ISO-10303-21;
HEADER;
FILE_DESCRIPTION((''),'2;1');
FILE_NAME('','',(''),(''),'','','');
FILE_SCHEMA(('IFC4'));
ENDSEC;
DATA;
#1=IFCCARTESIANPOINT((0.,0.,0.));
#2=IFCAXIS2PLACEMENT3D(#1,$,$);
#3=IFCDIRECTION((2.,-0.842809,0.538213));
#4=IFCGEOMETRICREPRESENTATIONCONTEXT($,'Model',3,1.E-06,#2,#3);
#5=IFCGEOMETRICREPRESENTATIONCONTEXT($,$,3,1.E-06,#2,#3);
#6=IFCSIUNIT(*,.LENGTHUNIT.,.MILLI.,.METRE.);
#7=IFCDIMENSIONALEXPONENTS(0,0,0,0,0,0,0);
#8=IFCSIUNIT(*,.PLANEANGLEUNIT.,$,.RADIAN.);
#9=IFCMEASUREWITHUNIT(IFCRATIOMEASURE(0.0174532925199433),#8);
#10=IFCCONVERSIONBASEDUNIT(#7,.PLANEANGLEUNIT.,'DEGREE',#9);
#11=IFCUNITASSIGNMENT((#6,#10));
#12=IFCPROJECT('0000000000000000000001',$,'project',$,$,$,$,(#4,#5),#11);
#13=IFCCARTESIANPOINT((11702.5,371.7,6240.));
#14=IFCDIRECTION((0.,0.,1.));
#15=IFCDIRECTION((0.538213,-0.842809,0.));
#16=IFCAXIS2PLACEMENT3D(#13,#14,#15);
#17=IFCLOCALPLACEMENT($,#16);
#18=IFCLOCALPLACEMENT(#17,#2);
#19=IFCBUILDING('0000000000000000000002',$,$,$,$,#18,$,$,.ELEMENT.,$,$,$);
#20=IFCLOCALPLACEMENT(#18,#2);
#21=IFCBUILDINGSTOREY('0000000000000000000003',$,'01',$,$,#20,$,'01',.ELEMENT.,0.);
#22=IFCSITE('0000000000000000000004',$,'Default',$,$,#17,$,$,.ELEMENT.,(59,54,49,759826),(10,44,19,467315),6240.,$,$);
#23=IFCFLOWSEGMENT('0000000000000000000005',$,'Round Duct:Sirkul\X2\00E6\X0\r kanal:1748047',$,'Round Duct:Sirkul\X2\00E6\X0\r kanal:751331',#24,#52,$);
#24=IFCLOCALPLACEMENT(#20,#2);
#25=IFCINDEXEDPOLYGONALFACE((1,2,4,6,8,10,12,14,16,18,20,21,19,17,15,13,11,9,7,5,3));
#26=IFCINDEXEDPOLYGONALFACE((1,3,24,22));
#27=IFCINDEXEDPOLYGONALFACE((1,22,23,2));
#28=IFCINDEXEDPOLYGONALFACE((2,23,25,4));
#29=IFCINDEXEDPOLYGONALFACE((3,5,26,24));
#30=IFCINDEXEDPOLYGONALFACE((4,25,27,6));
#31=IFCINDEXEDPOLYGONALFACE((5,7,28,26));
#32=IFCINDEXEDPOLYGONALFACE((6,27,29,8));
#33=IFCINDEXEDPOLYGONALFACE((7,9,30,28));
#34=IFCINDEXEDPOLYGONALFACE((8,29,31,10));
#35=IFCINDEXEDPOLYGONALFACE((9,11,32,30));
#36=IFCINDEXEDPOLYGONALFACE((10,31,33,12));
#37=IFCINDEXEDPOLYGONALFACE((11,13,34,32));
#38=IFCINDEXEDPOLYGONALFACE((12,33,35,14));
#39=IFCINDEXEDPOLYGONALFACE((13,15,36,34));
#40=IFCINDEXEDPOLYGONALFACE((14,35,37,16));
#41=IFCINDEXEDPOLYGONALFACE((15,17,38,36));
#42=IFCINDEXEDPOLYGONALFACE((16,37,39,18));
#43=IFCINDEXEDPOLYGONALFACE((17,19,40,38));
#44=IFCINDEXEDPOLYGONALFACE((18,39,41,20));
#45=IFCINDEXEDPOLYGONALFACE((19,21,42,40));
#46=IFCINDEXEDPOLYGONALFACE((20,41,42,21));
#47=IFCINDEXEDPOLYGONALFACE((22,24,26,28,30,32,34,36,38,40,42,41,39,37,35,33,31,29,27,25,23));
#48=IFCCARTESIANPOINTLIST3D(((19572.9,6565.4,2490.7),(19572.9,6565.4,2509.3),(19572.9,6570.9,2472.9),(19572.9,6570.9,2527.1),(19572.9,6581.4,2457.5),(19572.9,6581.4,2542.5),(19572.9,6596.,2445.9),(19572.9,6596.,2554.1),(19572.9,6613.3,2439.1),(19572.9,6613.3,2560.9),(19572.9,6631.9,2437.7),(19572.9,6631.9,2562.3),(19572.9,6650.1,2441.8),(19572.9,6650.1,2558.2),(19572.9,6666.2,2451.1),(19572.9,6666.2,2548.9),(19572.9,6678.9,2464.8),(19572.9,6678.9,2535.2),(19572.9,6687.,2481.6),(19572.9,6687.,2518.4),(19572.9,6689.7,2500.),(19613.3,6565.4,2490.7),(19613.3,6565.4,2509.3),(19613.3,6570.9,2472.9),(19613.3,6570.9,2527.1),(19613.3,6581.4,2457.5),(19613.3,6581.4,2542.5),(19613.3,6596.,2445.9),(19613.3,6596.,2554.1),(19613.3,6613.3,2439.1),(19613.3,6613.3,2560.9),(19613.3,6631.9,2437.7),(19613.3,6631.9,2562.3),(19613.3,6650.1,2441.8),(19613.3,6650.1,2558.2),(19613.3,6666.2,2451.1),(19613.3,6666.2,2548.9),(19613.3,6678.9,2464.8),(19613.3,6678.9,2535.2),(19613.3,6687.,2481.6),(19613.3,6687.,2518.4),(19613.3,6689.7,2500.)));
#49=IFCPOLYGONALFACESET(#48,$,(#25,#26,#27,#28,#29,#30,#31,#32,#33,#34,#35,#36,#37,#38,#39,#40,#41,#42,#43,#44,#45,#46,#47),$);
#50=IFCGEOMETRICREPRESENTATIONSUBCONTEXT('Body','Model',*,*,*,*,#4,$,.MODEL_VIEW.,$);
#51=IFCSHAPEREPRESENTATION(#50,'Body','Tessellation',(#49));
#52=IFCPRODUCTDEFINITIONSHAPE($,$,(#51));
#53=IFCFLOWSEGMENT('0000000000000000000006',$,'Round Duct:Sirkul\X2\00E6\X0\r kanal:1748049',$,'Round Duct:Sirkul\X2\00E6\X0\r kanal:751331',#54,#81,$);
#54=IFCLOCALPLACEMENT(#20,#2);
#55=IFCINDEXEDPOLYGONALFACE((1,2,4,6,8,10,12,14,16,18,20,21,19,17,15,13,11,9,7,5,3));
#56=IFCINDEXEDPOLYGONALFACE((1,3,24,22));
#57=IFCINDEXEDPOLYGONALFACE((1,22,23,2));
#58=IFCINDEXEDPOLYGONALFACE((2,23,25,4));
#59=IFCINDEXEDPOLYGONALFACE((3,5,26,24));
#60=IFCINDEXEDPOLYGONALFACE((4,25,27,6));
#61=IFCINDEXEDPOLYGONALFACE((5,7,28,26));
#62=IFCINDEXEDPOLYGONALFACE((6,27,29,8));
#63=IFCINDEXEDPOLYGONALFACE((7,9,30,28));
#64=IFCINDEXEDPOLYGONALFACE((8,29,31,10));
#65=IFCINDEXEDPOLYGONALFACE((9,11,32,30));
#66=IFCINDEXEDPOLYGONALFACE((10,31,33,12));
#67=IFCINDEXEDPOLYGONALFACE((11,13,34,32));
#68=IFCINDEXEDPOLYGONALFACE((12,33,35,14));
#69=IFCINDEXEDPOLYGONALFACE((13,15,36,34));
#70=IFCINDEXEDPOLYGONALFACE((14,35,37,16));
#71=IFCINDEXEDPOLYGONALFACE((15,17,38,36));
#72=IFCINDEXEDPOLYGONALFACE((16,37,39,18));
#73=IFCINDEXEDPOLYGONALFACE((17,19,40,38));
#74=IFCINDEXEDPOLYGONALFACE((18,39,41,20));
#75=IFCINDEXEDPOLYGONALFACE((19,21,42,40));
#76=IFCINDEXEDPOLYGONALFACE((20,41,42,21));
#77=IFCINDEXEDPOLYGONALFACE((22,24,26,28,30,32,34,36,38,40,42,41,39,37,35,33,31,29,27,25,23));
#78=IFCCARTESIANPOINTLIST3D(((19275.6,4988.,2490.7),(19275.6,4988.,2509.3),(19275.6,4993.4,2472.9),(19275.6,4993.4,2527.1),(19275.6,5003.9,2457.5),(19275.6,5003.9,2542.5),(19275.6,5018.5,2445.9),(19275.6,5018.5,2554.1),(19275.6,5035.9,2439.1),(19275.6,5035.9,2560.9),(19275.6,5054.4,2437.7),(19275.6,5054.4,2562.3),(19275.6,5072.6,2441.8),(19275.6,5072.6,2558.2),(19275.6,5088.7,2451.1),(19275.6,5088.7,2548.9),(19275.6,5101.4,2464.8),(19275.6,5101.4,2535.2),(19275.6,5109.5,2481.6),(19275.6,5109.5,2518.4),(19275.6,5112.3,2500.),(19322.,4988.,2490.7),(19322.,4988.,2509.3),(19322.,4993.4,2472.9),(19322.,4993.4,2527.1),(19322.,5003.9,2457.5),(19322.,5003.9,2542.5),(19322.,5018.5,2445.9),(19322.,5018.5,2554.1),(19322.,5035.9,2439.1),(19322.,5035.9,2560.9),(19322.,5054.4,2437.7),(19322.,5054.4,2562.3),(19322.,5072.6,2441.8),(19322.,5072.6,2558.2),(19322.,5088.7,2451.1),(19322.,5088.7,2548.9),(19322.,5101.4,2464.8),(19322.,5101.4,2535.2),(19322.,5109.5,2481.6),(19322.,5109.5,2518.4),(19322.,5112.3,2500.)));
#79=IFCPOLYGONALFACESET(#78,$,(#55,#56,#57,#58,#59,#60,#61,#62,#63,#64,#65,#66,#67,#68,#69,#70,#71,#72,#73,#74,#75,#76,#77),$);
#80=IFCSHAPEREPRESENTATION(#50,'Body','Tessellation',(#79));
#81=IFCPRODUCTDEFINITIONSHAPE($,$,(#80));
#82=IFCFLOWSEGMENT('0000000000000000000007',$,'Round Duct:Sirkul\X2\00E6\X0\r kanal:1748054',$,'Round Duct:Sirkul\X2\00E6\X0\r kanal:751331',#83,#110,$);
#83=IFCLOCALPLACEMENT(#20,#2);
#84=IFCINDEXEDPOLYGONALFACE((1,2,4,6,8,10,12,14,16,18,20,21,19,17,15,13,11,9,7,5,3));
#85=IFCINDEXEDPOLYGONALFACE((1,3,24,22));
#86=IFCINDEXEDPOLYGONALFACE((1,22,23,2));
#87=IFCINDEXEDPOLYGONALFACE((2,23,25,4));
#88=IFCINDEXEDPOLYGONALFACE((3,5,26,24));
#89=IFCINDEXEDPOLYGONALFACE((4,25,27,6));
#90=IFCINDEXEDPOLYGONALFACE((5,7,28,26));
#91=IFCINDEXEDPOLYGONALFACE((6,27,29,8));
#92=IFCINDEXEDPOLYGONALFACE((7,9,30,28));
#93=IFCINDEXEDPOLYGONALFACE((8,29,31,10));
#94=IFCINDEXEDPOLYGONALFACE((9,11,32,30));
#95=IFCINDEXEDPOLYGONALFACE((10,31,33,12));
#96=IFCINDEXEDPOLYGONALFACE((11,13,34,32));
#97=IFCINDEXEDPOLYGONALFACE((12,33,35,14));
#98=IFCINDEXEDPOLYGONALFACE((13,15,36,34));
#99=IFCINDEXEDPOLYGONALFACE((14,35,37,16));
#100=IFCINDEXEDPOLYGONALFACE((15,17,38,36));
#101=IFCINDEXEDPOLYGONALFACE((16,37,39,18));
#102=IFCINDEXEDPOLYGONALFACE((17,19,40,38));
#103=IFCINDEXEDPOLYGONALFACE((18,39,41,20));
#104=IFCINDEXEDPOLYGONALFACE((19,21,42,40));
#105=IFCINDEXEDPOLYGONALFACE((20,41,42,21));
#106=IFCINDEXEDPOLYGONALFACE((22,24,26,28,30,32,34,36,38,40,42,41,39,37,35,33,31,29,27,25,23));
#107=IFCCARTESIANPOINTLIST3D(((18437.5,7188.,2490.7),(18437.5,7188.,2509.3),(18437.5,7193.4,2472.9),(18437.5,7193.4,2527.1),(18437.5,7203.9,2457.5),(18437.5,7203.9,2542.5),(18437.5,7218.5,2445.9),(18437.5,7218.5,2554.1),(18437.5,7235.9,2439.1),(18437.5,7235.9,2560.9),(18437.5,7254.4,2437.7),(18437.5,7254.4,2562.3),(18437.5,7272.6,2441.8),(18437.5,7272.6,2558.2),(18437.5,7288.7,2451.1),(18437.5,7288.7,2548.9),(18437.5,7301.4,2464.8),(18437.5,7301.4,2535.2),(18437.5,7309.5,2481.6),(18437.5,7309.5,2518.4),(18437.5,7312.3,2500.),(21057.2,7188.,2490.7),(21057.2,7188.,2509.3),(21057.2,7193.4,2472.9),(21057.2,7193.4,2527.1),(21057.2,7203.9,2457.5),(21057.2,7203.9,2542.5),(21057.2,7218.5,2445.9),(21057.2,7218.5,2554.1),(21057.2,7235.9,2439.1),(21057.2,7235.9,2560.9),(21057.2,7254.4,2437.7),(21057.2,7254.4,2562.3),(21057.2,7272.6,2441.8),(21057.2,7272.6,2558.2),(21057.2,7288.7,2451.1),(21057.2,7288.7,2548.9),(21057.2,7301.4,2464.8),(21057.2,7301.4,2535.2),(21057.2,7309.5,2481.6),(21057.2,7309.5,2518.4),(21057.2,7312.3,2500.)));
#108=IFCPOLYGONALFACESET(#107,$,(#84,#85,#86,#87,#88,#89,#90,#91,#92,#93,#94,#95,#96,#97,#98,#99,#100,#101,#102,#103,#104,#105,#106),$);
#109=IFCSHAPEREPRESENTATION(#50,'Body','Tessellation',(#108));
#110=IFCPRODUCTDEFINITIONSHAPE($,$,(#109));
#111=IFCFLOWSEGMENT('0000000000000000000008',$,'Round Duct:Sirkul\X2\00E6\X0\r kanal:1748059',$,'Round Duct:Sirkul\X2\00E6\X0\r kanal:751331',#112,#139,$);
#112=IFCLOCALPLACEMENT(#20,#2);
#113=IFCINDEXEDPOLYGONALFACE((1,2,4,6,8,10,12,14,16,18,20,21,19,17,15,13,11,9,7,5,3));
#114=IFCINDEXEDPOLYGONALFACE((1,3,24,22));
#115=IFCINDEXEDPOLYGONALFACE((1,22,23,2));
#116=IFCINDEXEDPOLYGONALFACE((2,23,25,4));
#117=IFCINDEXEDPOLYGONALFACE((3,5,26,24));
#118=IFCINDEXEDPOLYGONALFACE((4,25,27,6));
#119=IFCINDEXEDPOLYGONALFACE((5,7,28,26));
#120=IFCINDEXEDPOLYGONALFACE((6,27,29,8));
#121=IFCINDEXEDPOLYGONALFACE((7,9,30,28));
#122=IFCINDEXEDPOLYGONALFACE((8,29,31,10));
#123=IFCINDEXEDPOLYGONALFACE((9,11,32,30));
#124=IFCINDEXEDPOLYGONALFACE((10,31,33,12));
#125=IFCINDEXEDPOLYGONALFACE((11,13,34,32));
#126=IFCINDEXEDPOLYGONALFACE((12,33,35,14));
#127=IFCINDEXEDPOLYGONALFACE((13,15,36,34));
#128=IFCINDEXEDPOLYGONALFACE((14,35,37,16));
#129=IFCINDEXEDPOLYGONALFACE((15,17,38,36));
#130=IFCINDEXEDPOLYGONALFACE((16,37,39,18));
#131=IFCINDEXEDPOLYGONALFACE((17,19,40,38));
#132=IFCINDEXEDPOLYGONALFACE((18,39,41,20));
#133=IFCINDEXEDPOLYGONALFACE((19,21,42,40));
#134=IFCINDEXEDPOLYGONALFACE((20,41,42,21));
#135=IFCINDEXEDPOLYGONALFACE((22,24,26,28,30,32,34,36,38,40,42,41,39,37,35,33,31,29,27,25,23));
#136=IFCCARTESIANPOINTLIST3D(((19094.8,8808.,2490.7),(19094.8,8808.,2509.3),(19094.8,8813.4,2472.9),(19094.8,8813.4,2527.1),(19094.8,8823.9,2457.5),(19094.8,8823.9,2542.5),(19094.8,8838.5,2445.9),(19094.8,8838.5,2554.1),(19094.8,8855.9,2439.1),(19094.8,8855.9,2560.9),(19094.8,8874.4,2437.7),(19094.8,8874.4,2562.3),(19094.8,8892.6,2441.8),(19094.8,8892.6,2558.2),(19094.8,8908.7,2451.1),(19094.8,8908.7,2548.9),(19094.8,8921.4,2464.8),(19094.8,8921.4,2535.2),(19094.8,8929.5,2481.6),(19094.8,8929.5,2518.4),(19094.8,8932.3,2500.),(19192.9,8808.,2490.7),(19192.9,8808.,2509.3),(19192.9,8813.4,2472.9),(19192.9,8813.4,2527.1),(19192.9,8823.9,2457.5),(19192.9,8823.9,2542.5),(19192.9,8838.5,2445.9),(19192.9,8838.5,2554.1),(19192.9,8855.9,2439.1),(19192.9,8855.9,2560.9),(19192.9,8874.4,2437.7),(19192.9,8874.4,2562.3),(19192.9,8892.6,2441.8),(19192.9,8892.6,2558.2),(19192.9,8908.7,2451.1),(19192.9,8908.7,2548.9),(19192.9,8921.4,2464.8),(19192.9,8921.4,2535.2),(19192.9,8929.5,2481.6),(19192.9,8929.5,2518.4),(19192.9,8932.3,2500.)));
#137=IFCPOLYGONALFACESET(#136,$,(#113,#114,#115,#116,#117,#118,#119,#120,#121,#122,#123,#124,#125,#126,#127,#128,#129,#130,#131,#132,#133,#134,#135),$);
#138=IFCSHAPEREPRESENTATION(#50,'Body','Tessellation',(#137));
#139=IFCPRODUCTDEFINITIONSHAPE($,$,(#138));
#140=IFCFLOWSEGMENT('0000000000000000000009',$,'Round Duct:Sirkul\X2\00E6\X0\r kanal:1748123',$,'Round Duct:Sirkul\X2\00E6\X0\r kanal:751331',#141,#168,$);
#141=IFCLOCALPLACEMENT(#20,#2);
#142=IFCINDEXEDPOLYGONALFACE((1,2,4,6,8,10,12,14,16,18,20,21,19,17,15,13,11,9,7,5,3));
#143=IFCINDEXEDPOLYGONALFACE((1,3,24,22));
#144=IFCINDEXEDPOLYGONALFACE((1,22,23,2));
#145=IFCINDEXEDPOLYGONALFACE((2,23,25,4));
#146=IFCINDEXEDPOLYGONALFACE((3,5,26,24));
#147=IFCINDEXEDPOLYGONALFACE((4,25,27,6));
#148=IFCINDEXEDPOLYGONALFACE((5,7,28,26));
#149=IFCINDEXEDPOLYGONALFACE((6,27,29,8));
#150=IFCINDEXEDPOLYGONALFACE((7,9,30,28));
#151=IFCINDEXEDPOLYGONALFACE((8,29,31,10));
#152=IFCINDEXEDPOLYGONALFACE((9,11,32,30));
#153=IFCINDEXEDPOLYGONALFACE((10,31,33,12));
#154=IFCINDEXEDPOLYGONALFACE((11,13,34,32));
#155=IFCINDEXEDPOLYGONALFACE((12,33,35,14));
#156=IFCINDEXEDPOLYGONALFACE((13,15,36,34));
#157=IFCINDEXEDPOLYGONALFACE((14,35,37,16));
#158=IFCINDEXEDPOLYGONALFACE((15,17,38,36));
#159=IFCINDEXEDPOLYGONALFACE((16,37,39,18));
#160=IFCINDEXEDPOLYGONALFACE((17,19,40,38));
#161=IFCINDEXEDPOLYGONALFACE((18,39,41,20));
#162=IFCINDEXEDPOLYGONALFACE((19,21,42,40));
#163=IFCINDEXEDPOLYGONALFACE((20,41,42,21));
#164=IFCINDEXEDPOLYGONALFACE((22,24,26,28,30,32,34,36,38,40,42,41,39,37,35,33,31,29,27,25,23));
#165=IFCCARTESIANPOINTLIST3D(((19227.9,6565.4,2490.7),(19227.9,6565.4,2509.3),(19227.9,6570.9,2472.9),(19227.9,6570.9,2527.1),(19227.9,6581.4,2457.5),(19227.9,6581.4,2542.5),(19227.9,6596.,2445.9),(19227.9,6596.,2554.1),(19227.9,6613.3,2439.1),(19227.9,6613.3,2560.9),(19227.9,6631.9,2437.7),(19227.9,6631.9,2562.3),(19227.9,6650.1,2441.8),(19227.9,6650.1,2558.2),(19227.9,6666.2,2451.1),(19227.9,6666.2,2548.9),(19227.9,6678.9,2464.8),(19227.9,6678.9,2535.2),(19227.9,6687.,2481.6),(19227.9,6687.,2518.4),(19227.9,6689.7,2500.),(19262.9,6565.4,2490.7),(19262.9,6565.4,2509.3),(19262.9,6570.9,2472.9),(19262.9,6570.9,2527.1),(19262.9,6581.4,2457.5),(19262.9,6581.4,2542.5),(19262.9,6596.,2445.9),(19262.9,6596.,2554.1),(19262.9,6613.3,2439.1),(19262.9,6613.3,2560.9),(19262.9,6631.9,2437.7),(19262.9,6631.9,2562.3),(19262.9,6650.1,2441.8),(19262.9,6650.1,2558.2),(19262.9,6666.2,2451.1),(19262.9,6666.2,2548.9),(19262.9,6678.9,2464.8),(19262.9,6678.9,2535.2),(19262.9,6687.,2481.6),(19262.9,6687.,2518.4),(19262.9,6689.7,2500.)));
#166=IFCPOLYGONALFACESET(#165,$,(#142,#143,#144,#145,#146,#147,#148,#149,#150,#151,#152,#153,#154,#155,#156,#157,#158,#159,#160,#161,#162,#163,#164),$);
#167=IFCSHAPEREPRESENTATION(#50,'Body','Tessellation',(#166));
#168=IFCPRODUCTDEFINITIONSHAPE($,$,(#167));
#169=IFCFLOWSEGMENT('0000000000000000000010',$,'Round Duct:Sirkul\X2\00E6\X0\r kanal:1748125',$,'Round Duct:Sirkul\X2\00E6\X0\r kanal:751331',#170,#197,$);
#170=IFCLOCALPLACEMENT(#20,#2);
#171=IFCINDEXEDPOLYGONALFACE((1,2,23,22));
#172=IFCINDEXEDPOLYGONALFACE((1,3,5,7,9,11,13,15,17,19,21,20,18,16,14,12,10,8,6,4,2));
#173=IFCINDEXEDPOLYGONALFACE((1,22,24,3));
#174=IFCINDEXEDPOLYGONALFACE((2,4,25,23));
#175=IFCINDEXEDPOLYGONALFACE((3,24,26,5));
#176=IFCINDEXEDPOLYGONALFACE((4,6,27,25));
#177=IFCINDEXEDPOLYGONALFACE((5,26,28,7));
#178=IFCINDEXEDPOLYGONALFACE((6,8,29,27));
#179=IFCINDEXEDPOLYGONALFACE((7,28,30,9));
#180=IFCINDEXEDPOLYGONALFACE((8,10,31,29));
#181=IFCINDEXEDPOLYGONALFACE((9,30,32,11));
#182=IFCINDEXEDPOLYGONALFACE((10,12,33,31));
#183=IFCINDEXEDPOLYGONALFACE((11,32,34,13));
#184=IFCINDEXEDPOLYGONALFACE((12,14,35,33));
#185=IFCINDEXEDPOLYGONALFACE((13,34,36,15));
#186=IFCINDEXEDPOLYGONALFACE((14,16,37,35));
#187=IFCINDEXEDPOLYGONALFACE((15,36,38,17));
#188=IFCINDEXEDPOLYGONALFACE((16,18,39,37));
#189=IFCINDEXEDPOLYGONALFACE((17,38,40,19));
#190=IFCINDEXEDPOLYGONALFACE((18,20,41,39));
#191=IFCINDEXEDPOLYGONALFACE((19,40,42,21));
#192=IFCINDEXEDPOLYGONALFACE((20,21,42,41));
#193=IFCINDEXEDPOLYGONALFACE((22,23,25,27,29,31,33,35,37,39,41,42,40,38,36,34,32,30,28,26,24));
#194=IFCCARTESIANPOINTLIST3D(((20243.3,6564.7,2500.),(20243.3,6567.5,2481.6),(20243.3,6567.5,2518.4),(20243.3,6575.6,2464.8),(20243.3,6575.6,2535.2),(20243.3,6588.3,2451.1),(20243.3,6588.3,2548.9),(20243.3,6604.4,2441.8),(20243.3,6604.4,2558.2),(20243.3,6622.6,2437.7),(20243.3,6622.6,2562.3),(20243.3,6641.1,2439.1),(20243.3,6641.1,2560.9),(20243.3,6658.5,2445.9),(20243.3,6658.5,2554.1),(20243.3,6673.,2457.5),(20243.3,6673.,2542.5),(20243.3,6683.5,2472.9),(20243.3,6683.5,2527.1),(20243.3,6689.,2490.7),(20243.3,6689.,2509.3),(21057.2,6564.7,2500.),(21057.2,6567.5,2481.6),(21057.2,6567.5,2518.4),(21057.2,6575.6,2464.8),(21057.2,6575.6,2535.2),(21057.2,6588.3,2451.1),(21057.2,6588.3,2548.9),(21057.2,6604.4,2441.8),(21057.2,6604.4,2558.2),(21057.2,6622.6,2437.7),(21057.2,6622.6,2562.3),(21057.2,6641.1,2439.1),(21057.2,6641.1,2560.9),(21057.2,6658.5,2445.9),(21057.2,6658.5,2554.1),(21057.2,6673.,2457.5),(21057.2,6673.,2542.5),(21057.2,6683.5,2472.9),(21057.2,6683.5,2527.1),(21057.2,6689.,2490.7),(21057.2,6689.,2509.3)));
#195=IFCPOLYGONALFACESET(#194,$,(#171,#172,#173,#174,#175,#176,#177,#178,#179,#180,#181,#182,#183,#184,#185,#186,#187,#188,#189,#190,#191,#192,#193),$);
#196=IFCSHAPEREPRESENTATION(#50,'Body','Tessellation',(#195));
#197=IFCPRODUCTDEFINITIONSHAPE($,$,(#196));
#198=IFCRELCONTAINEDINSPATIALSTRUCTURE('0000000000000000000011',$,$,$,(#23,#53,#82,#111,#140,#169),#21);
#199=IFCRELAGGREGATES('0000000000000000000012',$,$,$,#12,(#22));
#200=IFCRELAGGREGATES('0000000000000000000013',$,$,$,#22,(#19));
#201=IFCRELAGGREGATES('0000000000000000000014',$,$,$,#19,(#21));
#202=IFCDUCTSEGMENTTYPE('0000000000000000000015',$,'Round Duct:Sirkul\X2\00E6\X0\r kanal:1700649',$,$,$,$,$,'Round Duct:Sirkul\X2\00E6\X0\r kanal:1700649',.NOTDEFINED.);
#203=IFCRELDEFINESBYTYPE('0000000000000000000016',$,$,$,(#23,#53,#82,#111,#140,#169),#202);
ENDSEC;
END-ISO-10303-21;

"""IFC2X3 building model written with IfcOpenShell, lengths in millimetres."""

from ifc_helpers import new_model, entity, si_unit, converted_unit, direction, frame, frame_2d, origin, origin_2d_with_axis, place, context, subcontext, project, spatial, circle, extrude, type_object, element, save


model = new_model("IFC2X3")

# Units and contexts
model_context = context("Model", 3, precision=1e-06, world=origin(), true_north=direction((2.0, -0.842809, 0.538213)))
context_of_model = context(None, 3, precision=1e-06, world=origin(), true_north=direction((2.0, -0.842809, 0.538213)))
body_context = subcontext(model_context, "Body", "Model", "MODEL_VIEW")
ifc_project = project(units=[si_unit("LENGTHUNIT", "METRE", prefix="MILLI"), converted_unit("PLANEANGLEUNIT", "DEGREE", entity("IfcRatioMeasure", 0.0174532925199433), si_unit("PLANEANGLEUNIT", "RADIAN"), dimensions=[0, 0, 0, 0, 0, 0, 0])], contexts=[model_context, context_of_model])

# Site, building, storey
site_placement = place(None, frame((11702.5, 371.7, 6240.0), z_axis=(0.0, 0.0, 1.0), x_axis=(0.538213, -0.842809, 0.0)))
site = spatial("IfcSite", under=ifc_project, at=site_placement, Name="Default", CompositionType="ELEMENT", RefLatitude=(59, 54, 49, 759826), RefLongitude=(10, 44, 19, 467315), RefElevation=6240.0)
building_placement = place(site_placement, origin())
building = spatial("IfcBuilding", under=site, at=building_placement, CompositionType="ELEMENT")
storey_placement = place(building_placement, origin())
storey = spatial("IfcBuildingStorey", under=building, at=storey_placement, Name="01", LongName="01", CompositionType="ELEMENT", Elevation=0.0)

# Flow segments
duct_segment_type_1 = type_object("IfcDuctSegmentType", Name="Round Duct:Sirkulær kanal:1700649", ElementType="Round Duct:Sirkulær kanal:1700649", PredefinedType="NOTDEFINED")
flow_segment_1_placement = place(storey_placement, origin())
element("IfcFlowSegment", 1, at=flow_segment_1_placement, inside=storey, type_object=duct_segment_type_1, Name="Round Duct:Sirkulær kanal:1748047", ObjectType="Round Duct:Sirkulær kanal:751331", context=body_context, shape_type="SweptSolid", body=[
    extrude(circle(Radius=62.5, at=frame_2d((0.0, 0.0), x_axis=(1.0, 0.0))), frame((19572.9, 6627.2, 2500.0), z_axis=(1.0, 0.0, 0.0), x_axis=(0.0, 1.0, 0.0)), (0.0, 0.0, 1.0), 40.4),
])
flow_segment_2_placement = place(storey_placement, origin())
element("IfcFlowSegment", 2, at=flow_segment_2_placement, inside=storey, type_object=duct_segment_type_1, Name="Round Duct:Sirkulær kanal:1748049", ObjectType="Round Duct:Sirkulær kanal:751331", context=body_context, shape_type="SweptSolid", body=[
    extrude(circle(Radius=62.5, at=origin_2d_with_axis()), frame((19275.6, 5049.8, 2500.0), z_axis=(1.0, 0.0, 0.0), x_axis=(0.0, 1.0, 0.0)), (0.0, 0.0, 1.0), 46.5),
])
flow_segment_3_placement = place(storey_placement, origin())
element("IfcFlowSegment", 3, at=flow_segment_3_placement, inside=storey, type_object=duct_segment_type_1, Name="Round Duct:Sirkulær kanal:1748054", ObjectType="Round Duct:Sirkulær kanal:751331", context=body_context, shape_type="SweptSolid", body=[
    extrude(circle(Radius=62.5, at=frame_2d((0.0, 0.0), x_axis=(1.0, 0.0))), frame((18437.5, 7249.8, 2500.0), z_axis=(1.0, 0.0, 0.0), x_axis=(0.0, 1.0, 0.0)), (0.0, 0.0, 1.0), 2619.8),
])
flow_segment_4_placement = place(storey_placement, origin())
element("IfcFlowSegment", 4, at=flow_segment_4_placement, inside=storey, type_object=duct_segment_type_1, Name="Round Duct:Sirkulær kanal:1748059", ObjectType="Round Duct:Sirkulær kanal:751331", context=body_context, shape_type="SweptSolid", body=[
    extrude(circle(Radius=62.5, at=origin_2d_with_axis()), frame((19094.8, 8869.8, 2500.0), z_axis=(1.0, 0.0, 0.0), x_axis=(0.0, 1.0, 0.0)), (0.0, 0.0, 1.0), 98.1),
])
flow_segment_5_placement = place(storey_placement, origin())
element("IfcFlowSegment", 5, at=flow_segment_5_placement, inside=storey, type_object=duct_segment_type_1, Name="Round Duct:Sirkulær kanal:1748123", ObjectType="Round Duct:Sirkulær kanal:751331", context=body_context, shape_type="SweptSolid", body=[
    extrude(circle(Radius=62.5, at=frame_2d((0.0, 0.0), x_axis=(1.0, 0.0))), frame((19227.9, 6627.2, 2500.0), z_axis=(1.0, 0.0, 0.0), x_axis=(0.0, 1.0, 0.0)), (0.0, 0.0, 1.0), 35.0),
])
flow_segment_6_placement = place(storey_placement, origin())
element("IfcFlowSegment", 6, at=flow_segment_6_placement, inside=storey, type_object=duct_segment_type_1, Name="Round Duct:Sirkulær kanal:1748125", ObjectType="Round Duct:Sirkulær kanal:751331", context=body_context, shape_type="SweptSolid", body=[
    extrude(circle(Radius=62.5, at=origin_2d_with_axis()), frame((20243.3, 6627.2, 2500.0), z_axis=(1.0, 0.0, 0.0), x_axis=(0.0, -1.0, 0.0)), (0.0, 0.0, 1.0), 813.9),
])

save(model, "model.ifc")
